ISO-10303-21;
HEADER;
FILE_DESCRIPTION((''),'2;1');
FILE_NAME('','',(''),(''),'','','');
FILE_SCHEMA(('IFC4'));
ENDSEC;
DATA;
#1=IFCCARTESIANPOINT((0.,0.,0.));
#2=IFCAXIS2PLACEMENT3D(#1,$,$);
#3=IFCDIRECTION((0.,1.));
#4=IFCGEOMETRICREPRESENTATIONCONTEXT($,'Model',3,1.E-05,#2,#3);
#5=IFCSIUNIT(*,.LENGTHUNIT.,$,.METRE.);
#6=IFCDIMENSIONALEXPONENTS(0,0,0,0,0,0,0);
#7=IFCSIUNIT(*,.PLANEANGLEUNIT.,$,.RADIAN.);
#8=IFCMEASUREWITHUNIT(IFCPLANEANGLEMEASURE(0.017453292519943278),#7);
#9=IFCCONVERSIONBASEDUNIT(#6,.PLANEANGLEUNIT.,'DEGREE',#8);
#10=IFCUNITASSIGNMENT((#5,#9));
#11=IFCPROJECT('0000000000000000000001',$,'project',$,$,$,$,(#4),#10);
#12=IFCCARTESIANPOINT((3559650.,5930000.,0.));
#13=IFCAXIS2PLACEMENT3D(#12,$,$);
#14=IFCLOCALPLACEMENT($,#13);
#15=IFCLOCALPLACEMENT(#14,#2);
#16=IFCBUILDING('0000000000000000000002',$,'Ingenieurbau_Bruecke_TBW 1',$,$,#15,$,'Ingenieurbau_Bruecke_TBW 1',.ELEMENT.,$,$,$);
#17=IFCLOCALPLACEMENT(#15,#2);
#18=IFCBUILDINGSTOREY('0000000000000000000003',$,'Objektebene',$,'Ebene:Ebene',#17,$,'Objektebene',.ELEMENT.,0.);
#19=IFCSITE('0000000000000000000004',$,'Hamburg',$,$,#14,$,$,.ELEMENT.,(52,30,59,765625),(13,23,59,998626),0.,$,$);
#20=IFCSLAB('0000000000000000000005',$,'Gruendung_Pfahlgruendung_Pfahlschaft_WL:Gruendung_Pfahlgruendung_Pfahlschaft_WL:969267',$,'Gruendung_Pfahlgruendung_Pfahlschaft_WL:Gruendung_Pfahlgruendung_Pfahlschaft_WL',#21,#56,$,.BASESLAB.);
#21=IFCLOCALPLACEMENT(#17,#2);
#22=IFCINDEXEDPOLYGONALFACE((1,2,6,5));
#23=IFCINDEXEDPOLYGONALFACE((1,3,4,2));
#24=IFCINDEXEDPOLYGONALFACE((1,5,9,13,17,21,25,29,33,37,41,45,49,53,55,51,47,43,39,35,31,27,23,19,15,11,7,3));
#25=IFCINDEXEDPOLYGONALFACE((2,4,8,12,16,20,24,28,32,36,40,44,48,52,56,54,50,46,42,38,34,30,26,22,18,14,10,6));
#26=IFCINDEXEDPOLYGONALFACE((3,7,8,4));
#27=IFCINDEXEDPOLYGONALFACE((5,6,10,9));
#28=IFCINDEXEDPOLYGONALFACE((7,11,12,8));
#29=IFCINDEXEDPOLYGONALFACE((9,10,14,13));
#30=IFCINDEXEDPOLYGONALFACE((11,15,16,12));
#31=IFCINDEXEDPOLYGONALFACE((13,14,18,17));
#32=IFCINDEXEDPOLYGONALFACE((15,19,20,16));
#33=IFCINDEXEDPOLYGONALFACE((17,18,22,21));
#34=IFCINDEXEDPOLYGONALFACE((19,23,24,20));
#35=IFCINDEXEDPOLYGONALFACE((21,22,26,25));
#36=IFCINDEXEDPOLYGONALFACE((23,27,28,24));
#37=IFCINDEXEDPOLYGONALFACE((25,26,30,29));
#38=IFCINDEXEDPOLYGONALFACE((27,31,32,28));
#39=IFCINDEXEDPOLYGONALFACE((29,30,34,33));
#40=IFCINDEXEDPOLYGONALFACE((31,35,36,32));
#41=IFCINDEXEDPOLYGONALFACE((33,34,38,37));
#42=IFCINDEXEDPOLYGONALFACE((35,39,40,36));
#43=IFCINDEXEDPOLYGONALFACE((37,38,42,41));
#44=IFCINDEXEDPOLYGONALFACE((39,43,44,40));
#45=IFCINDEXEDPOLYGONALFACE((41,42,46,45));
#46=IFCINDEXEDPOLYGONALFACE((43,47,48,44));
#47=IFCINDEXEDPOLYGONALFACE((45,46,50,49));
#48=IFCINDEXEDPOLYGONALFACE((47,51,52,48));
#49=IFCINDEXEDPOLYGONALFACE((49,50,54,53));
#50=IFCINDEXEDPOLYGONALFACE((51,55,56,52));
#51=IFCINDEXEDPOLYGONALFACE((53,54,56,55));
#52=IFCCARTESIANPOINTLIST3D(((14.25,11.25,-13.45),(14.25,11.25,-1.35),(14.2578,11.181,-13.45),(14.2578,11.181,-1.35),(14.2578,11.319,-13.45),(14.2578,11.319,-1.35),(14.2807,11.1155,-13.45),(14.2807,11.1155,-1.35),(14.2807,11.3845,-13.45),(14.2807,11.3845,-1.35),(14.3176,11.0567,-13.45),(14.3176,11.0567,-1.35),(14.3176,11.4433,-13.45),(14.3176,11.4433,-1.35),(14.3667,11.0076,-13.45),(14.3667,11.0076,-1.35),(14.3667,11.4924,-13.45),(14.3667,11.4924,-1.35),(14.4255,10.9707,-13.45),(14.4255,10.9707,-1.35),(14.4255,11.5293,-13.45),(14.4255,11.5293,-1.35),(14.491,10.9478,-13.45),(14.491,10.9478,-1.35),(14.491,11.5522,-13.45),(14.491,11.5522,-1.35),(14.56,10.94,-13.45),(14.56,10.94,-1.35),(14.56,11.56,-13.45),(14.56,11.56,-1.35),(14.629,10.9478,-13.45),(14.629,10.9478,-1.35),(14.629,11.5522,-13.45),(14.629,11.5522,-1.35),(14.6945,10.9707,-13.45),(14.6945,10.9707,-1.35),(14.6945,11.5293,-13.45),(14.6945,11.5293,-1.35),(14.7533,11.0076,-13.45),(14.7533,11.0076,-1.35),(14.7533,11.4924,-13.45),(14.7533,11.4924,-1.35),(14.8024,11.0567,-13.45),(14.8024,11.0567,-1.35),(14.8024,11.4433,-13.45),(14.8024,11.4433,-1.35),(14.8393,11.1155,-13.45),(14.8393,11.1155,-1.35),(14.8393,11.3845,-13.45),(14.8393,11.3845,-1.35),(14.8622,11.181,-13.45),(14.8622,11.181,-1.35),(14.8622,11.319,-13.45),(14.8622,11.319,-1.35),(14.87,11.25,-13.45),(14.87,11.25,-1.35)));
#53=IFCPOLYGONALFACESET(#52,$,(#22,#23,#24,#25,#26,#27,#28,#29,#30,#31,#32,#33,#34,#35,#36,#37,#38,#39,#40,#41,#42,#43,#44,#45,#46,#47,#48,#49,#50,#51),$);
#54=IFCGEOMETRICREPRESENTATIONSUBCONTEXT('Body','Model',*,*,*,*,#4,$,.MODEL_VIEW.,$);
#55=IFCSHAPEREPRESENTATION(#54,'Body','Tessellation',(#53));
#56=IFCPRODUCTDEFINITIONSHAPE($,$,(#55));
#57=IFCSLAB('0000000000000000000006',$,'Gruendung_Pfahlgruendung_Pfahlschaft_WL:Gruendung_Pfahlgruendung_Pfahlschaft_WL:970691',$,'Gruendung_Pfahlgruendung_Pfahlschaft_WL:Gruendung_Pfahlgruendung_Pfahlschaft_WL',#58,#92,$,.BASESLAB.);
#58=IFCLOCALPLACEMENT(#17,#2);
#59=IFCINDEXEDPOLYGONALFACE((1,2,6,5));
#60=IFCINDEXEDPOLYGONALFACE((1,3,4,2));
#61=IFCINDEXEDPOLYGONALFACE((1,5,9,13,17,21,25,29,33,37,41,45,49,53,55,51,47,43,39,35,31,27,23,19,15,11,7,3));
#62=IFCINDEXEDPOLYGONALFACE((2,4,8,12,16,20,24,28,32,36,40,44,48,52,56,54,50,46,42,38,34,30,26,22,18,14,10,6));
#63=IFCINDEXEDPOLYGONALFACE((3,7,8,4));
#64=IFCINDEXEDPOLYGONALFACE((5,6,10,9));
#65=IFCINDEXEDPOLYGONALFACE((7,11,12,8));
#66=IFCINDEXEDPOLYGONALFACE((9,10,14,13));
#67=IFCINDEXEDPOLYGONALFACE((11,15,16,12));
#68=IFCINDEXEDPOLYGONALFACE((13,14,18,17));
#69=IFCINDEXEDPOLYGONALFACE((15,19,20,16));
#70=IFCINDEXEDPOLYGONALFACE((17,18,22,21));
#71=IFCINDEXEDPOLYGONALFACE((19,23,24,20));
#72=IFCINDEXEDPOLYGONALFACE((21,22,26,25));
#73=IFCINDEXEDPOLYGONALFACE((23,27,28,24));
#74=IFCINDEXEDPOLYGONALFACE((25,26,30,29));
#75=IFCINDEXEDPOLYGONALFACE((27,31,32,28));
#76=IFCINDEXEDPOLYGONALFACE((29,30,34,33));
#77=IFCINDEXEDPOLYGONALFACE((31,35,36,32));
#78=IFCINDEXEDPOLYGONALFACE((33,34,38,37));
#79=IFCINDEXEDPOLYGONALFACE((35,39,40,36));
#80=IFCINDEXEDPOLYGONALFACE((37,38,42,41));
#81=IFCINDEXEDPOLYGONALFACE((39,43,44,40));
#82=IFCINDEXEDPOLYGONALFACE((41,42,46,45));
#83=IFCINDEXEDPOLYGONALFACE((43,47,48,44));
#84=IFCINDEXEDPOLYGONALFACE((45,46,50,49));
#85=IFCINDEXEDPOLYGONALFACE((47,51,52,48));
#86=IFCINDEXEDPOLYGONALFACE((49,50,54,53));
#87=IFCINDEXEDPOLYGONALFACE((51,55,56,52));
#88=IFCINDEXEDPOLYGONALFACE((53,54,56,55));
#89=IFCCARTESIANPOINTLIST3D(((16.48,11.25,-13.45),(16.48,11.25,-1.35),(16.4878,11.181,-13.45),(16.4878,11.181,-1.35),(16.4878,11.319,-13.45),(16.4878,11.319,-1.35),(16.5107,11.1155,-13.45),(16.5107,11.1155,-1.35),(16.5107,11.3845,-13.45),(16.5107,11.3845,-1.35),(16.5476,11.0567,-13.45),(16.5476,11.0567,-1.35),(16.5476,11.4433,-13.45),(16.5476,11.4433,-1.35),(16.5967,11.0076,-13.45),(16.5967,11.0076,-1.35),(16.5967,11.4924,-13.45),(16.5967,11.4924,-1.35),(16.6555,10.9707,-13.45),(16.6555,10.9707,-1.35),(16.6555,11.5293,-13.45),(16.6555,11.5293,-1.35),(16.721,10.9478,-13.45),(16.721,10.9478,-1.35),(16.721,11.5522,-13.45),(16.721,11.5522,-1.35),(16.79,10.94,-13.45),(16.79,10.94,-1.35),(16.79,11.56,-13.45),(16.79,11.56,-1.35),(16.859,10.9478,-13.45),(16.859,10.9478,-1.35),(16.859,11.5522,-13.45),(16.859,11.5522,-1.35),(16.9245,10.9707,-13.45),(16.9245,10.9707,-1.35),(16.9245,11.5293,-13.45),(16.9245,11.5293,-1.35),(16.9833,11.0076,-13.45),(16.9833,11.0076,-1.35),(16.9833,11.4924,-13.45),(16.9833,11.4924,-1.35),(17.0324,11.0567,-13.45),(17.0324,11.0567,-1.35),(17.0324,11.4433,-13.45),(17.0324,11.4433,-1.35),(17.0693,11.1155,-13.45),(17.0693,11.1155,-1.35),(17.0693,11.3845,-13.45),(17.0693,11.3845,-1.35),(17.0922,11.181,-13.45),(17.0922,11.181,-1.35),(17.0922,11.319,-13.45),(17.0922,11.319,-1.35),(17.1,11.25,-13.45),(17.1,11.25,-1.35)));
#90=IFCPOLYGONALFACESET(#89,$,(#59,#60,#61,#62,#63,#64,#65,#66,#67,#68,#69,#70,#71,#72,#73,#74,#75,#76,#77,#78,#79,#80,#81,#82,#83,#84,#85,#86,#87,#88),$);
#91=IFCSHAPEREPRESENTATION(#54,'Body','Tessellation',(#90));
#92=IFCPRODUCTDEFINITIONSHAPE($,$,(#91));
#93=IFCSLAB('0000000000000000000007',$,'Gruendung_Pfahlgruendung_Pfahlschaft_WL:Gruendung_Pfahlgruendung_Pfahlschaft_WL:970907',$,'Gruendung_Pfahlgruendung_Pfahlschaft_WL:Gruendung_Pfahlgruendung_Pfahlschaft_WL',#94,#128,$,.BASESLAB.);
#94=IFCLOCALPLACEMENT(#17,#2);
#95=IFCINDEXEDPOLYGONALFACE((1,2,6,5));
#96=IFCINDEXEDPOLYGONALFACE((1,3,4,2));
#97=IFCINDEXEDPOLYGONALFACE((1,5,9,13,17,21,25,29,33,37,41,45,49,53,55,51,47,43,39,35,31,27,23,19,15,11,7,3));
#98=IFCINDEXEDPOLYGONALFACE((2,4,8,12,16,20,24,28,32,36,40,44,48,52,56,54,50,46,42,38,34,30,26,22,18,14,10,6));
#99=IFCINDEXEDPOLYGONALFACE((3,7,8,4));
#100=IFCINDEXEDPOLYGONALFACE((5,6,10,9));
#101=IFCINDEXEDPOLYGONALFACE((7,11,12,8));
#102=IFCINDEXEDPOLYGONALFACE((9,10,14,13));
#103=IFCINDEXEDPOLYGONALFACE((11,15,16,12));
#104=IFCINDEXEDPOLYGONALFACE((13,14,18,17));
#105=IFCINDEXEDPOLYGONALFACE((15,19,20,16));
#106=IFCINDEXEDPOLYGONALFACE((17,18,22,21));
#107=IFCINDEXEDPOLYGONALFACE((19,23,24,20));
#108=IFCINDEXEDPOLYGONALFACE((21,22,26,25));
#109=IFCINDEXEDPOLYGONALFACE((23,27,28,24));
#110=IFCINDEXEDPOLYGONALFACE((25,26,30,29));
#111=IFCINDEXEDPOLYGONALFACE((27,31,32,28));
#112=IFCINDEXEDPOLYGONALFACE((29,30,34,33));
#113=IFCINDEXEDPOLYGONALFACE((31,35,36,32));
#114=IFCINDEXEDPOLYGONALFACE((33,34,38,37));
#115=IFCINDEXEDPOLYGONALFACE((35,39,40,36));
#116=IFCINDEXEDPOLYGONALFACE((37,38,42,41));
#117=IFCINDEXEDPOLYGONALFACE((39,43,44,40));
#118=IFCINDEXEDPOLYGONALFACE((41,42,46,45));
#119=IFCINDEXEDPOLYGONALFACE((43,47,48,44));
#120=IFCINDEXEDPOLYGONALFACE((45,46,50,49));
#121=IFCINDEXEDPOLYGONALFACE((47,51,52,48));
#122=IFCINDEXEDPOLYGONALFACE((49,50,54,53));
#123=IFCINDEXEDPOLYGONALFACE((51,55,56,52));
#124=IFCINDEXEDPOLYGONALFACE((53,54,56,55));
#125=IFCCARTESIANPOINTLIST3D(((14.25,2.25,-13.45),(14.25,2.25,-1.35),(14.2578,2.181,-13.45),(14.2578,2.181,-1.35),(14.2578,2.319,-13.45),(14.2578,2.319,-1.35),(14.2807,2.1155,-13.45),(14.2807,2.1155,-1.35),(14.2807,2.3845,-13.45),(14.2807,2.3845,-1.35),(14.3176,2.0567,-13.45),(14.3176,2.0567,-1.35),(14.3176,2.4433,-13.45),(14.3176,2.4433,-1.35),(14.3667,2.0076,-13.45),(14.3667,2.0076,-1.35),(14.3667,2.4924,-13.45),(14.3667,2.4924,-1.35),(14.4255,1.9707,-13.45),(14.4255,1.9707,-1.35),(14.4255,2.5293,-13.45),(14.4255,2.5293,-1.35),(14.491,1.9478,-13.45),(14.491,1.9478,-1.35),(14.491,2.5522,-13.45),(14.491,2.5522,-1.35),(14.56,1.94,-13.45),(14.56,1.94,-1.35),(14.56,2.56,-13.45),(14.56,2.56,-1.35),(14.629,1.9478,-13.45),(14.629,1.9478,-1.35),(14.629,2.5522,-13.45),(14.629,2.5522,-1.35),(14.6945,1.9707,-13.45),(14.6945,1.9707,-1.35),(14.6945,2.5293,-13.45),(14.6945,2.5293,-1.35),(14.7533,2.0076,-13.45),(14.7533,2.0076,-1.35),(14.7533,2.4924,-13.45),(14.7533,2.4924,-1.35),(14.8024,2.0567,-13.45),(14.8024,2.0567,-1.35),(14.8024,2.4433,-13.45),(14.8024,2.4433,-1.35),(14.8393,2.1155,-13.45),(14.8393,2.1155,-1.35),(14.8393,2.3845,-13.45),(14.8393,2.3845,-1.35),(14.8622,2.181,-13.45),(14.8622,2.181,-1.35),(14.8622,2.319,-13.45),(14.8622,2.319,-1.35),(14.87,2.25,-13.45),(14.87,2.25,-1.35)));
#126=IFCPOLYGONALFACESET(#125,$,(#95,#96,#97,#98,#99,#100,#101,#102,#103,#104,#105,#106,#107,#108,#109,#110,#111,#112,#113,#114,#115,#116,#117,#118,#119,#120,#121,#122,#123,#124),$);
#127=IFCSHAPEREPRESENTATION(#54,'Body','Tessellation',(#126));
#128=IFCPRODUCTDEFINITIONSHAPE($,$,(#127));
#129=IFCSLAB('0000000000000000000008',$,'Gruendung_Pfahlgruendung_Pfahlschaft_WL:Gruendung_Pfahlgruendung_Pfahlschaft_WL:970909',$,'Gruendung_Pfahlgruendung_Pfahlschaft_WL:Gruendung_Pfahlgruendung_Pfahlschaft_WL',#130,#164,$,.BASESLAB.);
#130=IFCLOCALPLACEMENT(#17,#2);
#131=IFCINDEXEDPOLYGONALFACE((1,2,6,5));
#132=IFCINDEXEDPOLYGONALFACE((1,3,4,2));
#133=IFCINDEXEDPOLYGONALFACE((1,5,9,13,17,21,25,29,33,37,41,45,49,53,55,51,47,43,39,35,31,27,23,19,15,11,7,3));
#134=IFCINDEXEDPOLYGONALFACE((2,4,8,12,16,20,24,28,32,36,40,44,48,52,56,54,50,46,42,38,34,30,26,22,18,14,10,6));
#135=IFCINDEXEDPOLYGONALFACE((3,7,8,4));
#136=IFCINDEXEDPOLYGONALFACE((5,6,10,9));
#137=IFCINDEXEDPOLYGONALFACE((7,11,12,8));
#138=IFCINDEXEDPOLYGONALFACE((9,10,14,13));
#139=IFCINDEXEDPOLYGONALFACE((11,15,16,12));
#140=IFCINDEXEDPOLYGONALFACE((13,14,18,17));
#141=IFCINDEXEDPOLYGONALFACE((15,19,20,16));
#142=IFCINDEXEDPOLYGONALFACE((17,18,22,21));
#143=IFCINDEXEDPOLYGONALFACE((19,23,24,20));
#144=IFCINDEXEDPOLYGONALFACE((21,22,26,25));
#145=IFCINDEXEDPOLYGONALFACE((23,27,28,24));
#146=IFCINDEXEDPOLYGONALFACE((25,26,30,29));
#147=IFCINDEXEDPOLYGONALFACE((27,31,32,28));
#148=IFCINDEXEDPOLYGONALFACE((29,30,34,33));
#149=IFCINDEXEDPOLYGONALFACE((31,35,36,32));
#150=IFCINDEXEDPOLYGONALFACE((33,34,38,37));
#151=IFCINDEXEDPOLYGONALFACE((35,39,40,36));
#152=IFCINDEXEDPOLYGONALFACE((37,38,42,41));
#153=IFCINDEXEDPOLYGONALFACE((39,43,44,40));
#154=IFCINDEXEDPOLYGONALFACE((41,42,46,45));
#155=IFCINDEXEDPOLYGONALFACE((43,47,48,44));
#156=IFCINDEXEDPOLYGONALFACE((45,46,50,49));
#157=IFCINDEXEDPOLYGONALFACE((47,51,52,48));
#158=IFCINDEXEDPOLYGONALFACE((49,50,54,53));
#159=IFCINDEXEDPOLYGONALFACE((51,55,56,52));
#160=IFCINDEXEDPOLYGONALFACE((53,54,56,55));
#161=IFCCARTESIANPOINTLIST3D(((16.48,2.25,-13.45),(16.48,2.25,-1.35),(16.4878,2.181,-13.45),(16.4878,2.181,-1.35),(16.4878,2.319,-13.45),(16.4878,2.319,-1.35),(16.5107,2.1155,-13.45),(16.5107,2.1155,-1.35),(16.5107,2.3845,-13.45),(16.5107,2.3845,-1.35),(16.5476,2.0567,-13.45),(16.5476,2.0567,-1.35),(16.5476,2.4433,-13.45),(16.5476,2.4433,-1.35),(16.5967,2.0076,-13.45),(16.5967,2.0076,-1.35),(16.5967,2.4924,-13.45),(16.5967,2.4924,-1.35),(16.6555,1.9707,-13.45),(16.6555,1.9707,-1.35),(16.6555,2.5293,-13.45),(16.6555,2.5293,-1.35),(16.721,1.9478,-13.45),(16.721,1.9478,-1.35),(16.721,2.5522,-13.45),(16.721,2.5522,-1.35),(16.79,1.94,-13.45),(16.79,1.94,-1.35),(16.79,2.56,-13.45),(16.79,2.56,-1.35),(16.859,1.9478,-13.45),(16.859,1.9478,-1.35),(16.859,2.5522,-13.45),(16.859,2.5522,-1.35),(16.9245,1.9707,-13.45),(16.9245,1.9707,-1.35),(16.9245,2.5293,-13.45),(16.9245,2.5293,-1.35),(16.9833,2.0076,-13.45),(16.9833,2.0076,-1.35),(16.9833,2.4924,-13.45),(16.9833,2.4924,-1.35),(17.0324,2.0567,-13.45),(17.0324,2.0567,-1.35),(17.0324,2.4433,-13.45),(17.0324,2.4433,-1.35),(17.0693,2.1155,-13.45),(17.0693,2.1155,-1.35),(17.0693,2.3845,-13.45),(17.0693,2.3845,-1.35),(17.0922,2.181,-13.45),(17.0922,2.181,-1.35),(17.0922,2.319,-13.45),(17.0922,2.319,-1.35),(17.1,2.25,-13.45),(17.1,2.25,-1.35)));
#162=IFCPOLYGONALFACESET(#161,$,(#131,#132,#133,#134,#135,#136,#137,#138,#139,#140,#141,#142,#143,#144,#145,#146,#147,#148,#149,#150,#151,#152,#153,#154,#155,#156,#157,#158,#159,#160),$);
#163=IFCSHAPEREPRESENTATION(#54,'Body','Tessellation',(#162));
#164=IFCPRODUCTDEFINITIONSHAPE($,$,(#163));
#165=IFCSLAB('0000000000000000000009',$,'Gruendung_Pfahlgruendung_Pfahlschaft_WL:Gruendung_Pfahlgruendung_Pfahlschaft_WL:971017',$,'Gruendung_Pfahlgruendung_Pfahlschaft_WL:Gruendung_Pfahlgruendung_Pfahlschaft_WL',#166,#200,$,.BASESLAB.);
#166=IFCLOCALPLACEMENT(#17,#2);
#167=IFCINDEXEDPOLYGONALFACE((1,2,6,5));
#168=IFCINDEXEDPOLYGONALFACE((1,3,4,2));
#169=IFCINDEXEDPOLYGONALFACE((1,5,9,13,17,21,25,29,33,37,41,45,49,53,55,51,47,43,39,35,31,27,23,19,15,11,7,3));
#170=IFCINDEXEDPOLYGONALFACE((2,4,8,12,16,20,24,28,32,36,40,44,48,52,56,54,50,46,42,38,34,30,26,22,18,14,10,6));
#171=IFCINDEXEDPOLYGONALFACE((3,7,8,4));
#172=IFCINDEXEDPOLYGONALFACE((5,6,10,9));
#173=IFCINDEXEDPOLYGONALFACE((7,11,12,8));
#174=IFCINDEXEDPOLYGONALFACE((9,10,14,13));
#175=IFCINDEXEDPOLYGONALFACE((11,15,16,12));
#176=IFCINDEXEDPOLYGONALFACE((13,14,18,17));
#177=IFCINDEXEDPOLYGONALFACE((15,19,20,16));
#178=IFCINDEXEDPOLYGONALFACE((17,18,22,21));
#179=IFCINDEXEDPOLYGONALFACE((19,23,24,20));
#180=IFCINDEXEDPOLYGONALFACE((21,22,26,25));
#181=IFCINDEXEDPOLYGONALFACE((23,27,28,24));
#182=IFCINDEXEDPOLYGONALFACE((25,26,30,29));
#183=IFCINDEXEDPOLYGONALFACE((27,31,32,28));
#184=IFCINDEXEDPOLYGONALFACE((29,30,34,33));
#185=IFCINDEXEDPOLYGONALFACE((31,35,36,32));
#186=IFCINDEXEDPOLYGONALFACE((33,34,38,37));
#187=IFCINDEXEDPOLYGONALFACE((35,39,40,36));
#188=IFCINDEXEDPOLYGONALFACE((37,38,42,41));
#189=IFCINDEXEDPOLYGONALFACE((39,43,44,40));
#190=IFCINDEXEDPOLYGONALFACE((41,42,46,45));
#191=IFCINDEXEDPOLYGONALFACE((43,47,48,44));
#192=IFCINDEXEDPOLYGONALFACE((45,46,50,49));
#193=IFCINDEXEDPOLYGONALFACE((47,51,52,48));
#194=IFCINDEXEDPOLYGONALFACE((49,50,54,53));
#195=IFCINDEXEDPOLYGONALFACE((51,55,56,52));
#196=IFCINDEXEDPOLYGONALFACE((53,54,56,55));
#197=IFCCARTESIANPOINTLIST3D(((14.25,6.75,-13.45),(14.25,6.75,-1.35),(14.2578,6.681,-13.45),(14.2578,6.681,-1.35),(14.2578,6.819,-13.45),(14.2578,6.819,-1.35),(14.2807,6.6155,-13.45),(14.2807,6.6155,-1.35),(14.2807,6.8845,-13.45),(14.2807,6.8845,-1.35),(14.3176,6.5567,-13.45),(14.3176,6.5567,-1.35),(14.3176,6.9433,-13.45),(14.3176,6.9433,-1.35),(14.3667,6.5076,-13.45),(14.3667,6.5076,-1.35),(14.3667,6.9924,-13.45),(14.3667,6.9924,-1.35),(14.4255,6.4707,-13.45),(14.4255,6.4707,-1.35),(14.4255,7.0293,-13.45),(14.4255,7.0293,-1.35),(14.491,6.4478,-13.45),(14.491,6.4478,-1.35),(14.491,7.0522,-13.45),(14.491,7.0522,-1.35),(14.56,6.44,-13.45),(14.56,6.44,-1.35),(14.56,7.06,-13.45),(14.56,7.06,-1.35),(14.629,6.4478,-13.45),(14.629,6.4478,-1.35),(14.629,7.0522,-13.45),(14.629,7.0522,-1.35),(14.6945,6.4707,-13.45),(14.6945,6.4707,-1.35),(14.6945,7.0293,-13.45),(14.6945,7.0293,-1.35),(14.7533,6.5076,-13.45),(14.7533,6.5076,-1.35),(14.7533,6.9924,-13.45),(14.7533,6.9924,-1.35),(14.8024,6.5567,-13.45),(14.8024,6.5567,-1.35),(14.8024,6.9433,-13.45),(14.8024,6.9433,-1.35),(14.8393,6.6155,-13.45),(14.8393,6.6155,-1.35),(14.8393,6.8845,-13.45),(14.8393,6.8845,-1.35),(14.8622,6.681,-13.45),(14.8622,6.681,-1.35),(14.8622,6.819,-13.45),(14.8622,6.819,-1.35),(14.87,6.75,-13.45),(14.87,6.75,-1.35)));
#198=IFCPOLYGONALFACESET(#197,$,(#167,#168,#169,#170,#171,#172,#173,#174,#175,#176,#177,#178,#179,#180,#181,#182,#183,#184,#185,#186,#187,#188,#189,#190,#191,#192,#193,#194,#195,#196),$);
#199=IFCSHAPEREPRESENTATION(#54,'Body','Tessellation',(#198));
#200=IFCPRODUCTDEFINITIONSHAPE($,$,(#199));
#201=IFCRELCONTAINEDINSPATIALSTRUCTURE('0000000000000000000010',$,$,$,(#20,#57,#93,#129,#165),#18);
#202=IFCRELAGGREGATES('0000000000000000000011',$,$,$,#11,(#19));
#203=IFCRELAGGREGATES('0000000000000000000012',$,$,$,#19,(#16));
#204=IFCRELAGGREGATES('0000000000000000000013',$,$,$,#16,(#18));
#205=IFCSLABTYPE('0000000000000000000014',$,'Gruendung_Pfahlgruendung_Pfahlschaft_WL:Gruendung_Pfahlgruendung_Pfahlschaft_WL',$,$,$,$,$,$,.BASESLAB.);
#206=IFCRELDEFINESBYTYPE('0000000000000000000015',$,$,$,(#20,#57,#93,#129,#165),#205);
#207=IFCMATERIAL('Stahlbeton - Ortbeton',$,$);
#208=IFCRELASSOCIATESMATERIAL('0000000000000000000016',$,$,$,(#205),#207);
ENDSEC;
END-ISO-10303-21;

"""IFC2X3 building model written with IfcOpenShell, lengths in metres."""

from ifc_helpers import new_model, entity, si_unit, converted_unit, direction, frame, frame_2d, origin, origin_2d_with_axis, place, context, subcontext, project, spatial, circle, extrude, material, type_object, element, save


model = new_model("IFC2X3")

# Units and contexts
model_context = context("Model", 3, precision=1e-05, world=origin(), true_north=direction((0.0, 1.0)))
body_context = subcontext(model_context, "Body", "Model", "MODEL_VIEW")
ifc_project = project(units=[si_unit("LENGTHUNIT", "METRE"), converted_unit("PLANEANGLEUNIT", "DEGREE", entity("IfcPlaneAngleMeasure", 0.017453292519943278), si_unit("PLANEANGLEUNIT", "RADIAN"), dimensions=[0, 0, 0, 0, 0, 0, 0])], contexts=[model_context])

# Site, building, storey
site_placement = place(None, frame((3559650.0, 5930000.0, 0.0)))
site = spatial("IfcSite", under=ifc_project, at=site_placement, Name="Hamburg", CompositionType="ELEMENT", RefLatitude=(52, 30, 59, 765625), RefLongitude=(13, 23, 59, 998626), RefElevation=0.0)
building_placement = place(site_placement, origin())
building = spatial("IfcBuilding", under=site, at=building_placement, Name="Ingenieurbau_Bruecke_TBW 1", LongName="Ingenieurbau_Bruecke_TBW 1", CompositionType="ELEMENT")
storey_placement = place(building_placement, origin())
storey = spatial("IfcBuildingStorey", under=building, at=storey_placement, Name="Objektebene", ObjectType="Ebene:Ebene", LongName="Objektebene", CompositionType="ELEMENT", Elevation=0.0)

# Slabs
ifc_material_1 = material(Name="Stahlbeton - Ortbeton")
slab_type_1 = type_object("IfcSlabType", Name="Gruendung_Pfahlgruendung_Pfahlschaft_WL:Gruendung_Pfahlgruendung_Pfahlschaft_WL", PredefinedType="BASESLAB", material=ifc_material_1)
slab_1_placement = place(storey_placement, origin())
element("IfcSlab", 1, at=slab_1_placement, inside=storey, type_object=slab_type_1, Name="Gruendung_Pfahlgruendung_Pfahlschaft_WL:Gruendung_Pfahlgruendung_Pfahlschaft_WL:969267", ObjectType="Gruendung_Pfahlgruendung_Pfahlschaft_WL:Gruendung_Pfahlgruendung_Pfahlschaft_WL", PredefinedType="BASESLAB", context=body_context, shape_type="SweptSolid", body=[
    extrude(circle(Radius=0.31, at=origin_2d_with_axis()), frame((14.56, 11.25, -13.45)), (0.0, 0.0, 1.0), 12.1),
])
slab_2_placement = place(storey_placement, origin())
element("IfcSlab", 2, at=slab_2_placement, inside=storey, type_object=slab_type_1, Name="Gruendung_Pfahlgruendung_Pfahlschaft_WL:Gruendung_Pfahlgruendung_Pfahlschaft_WL:970691", ObjectType="Gruendung_Pfahlgruendung_Pfahlschaft_WL:Gruendung_Pfahlgruendung_Pfahlschaft_WL", PredefinedType="BASESLAB", context=body_context, shape_type="SweptSolid", body=[
    extrude(circle(Radius=0.31, at=origin_2d_with_axis()), frame((16.79, 11.25, -13.45), z_axis=(0.0, 0.0, 1.0), x_axis=(-1.0, 0.0, 0.0)), (0.0, 0.0, 1.0), 12.1),
])
slab_3_placement = place(storey_placement, origin())
element("IfcSlab", 3, at=slab_3_placement, inside=storey, type_object=slab_type_1, Name="Gruendung_Pfahlgruendung_Pfahlschaft_WL:Gruendung_Pfahlgruendung_Pfahlschaft_WL:970907", ObjectType="Gruendung_Pfahlgruendung_Pfahlschaft_WL:Gruendung_Pfahlgruendung_Pfahlschaft_WL", PredefinedType="BASESLAB", context=body_context, shape_type="SweptSolid", body=[
    extrude(circle(Radius=0.31, at=frame_2d((0.0, 0.0), x_axis=(1.0, 0.0))), frame((14.56, 2.25, -13.45)), (0.0, 0.0, 1.0), 12.1),
])
slab_4_placement = place(storey_placement, origin())
element("IfcSlab", 4, at=slab_4_placement, inside=storey, type_object=slab_type_1, Name="Gruendung_Pfahlgruendung_Pfahlschaft_WL:Gruendung_Pfahlgruendung_Pfahlschaft_WL:970909", ObjectType="Gruendung_Pfahlgruendung_Pfahlschaft_WL:Gruendung_Pfahlgruendung_Pfahlschaft_WL", PredefinedType="BASESLAB", context=body_context, shape_type="SweptSolid", body=[
    extrude(circle(Radius=0.31, at=frame_2d((0.0, 0.0), x_axis=(1.0, 0.0))), frame((16.79, 2.25, -13.45), z_axis=(0.0, 0.0, 1.0), x_axis=(-1.0, 0.0, 0.0)), (0.0, 0.0, 1.0), 12.1),
])
slab_5_placement = place(storey_placement, origin())
element("IfcSlab", 5, at=slab_5_placement, inside=storey, type_object=slab_type_1, Name="Gruendung_Pfahlgruendung_Pfahlschaft_WL:Gruendung_Pfahlgruendung_Pfahlschaft_WL:971017", ObjectType="Gruendung_Pfahlgruendung_Pfahlschaft_WL:Gruendung_Pfahlgruendung_Pfahlschaft_WL", PredefinedType="BASESLAB", context=body_context, shape_type="SweptSolid", body=[
    extrude(circle(Radius=0.31, at=frame_2d((0.0, 0.0), x_axis=(1.0, 0.0))), frame((14.56, 6.75, -13.45)), (0.0, 0.0, 1.0), 12.1),
])

save(model, "model.ifc")
